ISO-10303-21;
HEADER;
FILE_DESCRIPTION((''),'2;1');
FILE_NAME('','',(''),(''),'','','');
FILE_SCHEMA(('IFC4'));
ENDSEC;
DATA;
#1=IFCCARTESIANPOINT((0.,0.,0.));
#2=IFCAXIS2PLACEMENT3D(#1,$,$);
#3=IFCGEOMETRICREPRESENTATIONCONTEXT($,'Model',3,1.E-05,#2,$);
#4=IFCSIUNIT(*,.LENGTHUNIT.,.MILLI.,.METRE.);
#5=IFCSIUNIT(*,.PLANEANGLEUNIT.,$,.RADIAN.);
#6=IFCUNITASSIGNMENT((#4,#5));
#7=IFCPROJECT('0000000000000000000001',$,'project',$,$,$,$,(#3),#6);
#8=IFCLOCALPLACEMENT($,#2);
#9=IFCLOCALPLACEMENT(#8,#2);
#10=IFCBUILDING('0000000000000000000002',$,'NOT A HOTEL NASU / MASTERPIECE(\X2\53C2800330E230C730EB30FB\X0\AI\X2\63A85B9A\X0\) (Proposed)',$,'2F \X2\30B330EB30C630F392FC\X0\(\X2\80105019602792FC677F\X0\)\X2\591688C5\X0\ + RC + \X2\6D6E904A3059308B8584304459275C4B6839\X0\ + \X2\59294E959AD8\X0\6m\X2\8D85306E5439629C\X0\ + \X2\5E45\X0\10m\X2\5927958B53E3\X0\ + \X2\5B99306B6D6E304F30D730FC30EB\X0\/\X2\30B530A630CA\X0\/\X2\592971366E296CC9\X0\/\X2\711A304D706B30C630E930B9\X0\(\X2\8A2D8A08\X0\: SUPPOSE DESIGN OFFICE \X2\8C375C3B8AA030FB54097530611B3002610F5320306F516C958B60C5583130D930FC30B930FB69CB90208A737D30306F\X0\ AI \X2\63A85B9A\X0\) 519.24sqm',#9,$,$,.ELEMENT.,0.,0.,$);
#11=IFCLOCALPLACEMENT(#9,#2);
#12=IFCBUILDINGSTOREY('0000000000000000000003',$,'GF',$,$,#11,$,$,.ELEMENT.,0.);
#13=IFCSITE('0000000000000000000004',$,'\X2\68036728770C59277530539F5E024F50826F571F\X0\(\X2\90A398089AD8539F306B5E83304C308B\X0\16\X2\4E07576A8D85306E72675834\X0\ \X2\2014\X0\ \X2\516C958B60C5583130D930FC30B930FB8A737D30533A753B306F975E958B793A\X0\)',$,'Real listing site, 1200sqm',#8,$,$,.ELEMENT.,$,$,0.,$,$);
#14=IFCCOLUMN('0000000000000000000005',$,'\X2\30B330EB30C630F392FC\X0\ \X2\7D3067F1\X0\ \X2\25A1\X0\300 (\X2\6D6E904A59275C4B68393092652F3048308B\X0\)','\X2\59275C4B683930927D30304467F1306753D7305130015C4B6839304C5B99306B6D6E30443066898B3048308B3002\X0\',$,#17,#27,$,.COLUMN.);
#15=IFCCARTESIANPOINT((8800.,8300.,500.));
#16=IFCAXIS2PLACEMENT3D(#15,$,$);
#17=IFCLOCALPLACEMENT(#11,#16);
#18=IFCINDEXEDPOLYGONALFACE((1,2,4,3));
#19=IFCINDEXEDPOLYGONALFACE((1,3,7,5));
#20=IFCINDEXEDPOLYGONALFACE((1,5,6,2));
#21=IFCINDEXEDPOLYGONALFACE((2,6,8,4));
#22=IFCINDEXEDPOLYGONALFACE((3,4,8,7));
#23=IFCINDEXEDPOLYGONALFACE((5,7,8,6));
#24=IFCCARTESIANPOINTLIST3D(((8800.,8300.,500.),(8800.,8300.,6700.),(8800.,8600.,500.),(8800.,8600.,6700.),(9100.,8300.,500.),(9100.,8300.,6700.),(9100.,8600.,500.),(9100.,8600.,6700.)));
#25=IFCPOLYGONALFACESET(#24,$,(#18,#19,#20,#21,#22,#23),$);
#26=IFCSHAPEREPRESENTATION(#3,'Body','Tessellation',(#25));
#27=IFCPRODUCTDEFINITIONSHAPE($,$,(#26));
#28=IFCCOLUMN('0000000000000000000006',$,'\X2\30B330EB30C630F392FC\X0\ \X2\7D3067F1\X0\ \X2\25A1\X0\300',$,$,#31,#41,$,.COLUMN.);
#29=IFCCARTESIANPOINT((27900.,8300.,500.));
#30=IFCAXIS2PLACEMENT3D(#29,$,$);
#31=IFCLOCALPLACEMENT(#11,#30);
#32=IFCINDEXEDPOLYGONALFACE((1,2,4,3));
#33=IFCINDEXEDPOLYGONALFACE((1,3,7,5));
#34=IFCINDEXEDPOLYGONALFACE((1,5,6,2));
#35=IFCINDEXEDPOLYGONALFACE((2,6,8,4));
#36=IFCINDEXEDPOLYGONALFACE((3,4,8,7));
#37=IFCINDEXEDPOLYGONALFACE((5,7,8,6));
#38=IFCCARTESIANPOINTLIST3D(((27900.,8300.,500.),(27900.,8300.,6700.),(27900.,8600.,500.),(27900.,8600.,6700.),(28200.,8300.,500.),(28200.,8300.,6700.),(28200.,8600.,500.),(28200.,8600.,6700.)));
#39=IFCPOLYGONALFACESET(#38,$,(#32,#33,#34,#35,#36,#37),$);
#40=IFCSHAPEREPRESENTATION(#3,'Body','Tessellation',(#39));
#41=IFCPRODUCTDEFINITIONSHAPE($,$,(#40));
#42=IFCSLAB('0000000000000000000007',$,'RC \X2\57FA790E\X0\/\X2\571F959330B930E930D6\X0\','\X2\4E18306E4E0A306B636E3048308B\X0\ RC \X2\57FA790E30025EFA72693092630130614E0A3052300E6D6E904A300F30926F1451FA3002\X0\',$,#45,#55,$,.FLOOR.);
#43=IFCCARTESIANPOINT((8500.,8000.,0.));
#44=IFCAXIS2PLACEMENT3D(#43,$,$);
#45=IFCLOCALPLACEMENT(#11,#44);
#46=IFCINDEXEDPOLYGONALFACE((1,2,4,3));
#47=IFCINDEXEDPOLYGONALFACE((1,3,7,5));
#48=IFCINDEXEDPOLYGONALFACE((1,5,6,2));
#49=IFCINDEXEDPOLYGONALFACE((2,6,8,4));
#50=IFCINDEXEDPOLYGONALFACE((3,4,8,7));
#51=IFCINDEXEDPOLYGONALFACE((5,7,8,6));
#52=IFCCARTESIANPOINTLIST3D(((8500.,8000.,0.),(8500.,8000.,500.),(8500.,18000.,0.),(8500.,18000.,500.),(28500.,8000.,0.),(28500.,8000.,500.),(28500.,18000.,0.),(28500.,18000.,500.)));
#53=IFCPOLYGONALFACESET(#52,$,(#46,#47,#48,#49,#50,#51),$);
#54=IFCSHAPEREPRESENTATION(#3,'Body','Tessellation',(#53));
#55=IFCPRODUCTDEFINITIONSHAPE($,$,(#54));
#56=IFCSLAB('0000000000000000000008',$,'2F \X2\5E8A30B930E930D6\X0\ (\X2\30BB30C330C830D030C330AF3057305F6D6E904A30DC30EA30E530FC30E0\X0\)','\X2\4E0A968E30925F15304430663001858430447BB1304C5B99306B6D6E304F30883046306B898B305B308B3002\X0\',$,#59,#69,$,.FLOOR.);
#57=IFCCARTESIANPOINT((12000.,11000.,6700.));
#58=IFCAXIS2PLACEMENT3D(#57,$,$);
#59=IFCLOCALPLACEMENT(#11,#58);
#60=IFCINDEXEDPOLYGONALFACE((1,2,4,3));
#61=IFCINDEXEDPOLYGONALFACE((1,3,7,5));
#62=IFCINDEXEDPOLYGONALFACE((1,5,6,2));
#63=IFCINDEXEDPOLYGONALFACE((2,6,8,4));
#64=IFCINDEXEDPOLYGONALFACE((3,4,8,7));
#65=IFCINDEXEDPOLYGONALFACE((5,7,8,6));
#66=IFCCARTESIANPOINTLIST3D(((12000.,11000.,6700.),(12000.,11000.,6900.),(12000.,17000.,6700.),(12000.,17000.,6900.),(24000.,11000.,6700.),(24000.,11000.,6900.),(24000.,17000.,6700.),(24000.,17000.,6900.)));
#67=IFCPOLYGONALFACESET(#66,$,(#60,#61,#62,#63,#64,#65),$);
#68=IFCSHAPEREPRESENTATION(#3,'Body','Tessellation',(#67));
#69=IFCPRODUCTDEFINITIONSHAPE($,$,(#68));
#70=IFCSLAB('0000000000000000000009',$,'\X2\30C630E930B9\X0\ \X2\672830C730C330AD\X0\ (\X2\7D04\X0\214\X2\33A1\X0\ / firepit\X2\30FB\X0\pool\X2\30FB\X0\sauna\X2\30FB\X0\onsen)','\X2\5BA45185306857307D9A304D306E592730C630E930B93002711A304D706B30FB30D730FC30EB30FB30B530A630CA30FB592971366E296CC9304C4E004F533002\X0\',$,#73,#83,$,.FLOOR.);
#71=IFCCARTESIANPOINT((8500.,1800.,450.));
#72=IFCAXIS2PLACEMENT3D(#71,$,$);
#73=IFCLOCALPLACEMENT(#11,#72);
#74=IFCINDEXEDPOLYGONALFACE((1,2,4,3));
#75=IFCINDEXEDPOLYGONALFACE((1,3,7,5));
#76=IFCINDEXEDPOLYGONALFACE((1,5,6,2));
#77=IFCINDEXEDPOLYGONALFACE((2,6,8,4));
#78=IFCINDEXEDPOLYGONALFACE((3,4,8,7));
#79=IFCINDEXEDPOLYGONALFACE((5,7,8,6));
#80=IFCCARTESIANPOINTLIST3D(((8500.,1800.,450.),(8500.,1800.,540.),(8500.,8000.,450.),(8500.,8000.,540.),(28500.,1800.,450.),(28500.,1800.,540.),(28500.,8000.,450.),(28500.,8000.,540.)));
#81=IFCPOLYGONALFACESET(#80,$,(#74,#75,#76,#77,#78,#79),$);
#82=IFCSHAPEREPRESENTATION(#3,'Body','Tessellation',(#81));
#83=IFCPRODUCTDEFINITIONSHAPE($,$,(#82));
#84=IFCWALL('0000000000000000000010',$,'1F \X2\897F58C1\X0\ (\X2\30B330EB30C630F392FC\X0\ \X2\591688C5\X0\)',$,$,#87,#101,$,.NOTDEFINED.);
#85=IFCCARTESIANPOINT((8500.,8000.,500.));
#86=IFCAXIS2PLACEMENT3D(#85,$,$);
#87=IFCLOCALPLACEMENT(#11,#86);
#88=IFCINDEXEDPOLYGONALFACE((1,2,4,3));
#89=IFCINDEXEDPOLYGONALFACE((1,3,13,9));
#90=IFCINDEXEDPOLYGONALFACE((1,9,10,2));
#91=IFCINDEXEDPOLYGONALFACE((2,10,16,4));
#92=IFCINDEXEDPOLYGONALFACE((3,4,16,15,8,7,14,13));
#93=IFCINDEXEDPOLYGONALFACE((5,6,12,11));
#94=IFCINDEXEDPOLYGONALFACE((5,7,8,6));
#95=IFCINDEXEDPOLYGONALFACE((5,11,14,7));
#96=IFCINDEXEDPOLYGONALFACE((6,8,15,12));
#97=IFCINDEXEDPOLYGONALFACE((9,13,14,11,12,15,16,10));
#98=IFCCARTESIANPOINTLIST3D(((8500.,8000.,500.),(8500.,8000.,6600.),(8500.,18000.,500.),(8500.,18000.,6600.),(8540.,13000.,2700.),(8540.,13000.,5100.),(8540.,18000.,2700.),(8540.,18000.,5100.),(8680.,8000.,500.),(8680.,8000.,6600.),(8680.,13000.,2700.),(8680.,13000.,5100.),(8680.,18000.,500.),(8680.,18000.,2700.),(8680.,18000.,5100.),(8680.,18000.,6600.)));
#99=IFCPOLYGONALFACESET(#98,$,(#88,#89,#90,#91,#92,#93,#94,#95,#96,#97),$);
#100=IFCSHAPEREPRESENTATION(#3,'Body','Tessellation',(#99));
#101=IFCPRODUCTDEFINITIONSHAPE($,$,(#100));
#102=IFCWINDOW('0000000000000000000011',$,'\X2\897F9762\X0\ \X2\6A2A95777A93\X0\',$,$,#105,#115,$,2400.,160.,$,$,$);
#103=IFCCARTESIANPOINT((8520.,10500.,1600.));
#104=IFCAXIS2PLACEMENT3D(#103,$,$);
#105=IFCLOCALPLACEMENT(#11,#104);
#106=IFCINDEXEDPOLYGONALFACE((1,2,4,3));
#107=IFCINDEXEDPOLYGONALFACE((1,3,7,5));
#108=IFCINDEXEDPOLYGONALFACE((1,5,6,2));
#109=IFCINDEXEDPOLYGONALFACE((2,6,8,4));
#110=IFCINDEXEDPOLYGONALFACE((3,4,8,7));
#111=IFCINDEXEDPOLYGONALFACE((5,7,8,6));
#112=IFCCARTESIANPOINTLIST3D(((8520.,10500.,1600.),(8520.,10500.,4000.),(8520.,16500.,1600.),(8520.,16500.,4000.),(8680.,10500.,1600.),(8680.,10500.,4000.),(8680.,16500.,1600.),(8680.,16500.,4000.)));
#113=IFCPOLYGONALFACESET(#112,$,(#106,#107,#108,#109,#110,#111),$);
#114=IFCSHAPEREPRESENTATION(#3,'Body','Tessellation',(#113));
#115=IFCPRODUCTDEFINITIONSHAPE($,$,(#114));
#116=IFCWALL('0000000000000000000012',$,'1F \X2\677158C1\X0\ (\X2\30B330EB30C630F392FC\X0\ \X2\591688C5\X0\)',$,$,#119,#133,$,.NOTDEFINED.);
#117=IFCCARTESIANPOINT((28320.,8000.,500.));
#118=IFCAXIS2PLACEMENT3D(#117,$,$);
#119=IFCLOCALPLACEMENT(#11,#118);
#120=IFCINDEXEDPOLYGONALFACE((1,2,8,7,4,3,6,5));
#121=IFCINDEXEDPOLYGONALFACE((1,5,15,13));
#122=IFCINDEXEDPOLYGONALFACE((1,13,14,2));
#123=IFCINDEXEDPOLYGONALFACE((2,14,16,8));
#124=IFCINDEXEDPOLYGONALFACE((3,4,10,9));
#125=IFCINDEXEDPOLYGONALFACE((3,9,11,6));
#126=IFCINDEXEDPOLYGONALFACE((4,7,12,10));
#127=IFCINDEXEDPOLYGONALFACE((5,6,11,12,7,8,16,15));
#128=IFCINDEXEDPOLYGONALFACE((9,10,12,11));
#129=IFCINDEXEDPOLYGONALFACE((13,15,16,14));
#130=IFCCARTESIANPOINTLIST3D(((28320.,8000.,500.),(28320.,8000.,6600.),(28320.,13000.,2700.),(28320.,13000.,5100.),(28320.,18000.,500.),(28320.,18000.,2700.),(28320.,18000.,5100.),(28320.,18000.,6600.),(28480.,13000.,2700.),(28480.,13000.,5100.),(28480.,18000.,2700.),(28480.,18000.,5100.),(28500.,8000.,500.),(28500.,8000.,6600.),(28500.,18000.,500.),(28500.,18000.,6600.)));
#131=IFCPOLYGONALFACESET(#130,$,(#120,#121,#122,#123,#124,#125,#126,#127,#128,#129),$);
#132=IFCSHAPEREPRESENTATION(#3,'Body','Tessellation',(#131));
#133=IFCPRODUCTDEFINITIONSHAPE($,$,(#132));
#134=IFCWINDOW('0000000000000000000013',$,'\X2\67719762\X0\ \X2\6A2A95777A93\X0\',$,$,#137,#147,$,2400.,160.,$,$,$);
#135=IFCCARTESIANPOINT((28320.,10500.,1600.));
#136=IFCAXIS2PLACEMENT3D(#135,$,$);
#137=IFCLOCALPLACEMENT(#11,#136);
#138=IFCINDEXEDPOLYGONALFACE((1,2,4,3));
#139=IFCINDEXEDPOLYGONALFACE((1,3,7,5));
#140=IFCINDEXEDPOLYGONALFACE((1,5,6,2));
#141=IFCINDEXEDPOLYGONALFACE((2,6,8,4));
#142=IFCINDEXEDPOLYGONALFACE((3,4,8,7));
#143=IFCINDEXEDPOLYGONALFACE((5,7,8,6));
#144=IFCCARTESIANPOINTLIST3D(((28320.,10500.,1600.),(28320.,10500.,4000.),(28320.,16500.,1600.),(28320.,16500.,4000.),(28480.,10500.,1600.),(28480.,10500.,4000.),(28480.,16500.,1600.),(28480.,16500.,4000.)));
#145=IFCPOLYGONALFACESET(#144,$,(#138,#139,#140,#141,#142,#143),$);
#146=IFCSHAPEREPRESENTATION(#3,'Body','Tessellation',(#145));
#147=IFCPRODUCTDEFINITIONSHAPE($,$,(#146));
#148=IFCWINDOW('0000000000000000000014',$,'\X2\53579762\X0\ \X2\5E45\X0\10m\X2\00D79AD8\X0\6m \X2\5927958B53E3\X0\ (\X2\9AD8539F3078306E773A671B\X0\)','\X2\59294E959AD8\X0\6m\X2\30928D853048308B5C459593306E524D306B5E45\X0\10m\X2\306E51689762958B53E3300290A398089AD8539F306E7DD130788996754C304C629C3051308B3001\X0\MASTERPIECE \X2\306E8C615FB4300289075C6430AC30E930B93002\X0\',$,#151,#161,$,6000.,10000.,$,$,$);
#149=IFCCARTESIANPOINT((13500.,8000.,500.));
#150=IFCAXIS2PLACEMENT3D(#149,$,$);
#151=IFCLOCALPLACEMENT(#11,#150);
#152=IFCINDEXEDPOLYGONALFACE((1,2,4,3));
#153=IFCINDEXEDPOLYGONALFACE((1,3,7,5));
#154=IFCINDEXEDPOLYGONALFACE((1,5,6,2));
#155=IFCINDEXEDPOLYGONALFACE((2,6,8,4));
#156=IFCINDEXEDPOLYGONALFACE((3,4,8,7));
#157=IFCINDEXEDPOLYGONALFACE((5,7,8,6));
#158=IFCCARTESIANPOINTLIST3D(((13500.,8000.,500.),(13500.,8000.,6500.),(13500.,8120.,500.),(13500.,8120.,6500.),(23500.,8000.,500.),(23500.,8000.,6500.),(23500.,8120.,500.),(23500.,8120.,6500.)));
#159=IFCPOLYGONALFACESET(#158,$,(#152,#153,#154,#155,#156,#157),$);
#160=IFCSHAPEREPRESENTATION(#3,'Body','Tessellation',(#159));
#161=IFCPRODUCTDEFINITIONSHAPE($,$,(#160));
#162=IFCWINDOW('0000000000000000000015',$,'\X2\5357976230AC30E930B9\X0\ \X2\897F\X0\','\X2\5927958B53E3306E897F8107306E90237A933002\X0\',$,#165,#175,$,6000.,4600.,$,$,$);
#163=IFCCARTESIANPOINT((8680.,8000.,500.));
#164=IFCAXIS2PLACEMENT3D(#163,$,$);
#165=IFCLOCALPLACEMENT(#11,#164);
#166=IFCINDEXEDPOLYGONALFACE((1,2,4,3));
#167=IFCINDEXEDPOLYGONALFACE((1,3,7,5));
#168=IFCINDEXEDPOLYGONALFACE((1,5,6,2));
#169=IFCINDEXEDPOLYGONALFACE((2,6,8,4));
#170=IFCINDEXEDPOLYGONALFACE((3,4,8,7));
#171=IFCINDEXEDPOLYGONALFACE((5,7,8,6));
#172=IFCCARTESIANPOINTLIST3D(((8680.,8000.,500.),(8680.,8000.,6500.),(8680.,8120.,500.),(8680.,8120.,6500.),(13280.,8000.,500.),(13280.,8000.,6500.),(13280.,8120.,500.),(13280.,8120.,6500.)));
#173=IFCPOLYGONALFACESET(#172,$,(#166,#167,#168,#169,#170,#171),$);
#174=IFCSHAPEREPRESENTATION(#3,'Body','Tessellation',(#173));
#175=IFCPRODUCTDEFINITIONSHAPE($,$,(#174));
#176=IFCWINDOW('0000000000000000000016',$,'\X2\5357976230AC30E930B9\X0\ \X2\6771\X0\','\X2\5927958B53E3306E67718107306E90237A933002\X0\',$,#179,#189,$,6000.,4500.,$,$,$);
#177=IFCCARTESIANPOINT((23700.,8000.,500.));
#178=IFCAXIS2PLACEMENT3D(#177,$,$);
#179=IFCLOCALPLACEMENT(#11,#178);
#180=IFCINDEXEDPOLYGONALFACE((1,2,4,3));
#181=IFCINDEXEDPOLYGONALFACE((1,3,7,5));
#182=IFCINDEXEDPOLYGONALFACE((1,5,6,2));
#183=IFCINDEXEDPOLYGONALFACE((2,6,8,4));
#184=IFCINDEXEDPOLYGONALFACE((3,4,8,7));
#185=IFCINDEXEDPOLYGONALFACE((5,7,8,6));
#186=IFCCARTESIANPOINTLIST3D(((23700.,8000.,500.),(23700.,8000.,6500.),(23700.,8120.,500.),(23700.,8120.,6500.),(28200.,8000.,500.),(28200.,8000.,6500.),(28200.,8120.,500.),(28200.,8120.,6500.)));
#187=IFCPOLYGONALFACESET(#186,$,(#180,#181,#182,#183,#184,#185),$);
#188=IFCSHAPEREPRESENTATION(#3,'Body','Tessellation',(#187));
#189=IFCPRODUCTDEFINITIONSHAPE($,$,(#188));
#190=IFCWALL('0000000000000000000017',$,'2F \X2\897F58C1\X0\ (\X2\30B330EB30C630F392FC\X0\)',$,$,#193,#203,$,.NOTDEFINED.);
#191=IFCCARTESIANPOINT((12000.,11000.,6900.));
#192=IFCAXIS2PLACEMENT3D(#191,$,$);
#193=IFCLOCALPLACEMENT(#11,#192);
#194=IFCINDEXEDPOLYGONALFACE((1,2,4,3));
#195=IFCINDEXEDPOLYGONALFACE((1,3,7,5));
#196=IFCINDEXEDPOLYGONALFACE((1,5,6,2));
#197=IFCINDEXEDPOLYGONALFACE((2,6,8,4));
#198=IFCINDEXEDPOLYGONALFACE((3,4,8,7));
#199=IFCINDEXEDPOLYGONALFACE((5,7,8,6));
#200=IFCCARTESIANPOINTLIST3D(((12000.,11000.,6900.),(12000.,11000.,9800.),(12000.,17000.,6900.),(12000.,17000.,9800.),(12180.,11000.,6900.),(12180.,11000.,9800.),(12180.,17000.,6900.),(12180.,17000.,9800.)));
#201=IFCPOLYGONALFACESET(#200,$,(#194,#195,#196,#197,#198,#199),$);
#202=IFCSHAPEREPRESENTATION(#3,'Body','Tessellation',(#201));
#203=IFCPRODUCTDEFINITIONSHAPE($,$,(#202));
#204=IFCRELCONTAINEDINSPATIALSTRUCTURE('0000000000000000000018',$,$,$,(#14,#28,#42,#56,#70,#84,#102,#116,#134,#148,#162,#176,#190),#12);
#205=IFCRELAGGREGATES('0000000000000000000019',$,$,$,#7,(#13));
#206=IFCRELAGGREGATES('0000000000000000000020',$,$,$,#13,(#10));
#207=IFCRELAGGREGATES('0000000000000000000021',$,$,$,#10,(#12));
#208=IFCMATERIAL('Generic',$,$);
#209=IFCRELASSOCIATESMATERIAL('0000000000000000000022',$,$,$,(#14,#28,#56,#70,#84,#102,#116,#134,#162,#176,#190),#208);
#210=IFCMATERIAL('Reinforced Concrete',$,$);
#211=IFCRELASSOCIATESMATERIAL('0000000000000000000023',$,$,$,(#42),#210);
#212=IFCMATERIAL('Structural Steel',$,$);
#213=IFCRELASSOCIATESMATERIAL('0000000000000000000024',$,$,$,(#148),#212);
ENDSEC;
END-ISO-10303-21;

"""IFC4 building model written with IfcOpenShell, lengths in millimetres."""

from ifc_helpers import new_model, si_unit, frame, frame_2d, origin, place, context, project, spatial, rectangle, extrude, material, element, fill, save


model = new_model("IFC4")

# Units and contexts
model_context = context("Model", 3, precision=1e-05, world=origin())
ifc_project = project(units=[si_unit("LENGTHUNIT", "METRE", prefix="MILLI"), si_unit("PLANEANGLEUNIT", "RADIAN")], contexts=[model_context])

# Site, building, storey
site_placement = place(None, origin())
site = spatial("IfcSite", under=ifc_project, at=site_placement, Name="栃木県大田原市佐良土(那須高原に広がる16万坪超の牧場 — 公開情報ベース・詳細区画は非開示)", ObjectType="Real listing site, 1200sqm", CompositionType="ELEMENT", RefElevation=0.0)
building_placement = place(site_placement, origin())
building = spatial("IfcBuilding", under=site, at=building_placement, Name="NOT A HOTEL NASU / MASTERPIECE(参考モデル・AI推定) (Proposed)", ObjectType="2F コルテン鋼(耐候性鋼板)外装 + RC + 浮遊する薄い大屋根 + 天井高6m超の吹抜 + 幅10m大開口 + 宙に浮くプール/サウナ/天然温泉/焚き火テラス(設計: SUPPOSE DESIGN OFFICE 谷尻誠・吉田愛。意匠は公開情報ベース・構造詳細は AI 推定) 519.24sqm", CompositionType="ELEMENT", ElevationOfRefHeight=0.0, ElevationOfTerrain=0.0)
storey_placement = place(building_placement, origin())
storey = spatial("IfcBuildingStorey", under=building, at=storey_placement, Name="GF", CompositionType="ELEMENT", Elevation=0.0)

# Columns
ifc_material_1 = material(Name="Generic")
column_1_placement = place(storey_placement, frame((8800.0, 8300.0, 500.0)))
element("IfcColumn", 1, at=column_1_placement, inside=storey, material=ifc_material_1, Name="コルテン鋼 細柱 □300 (浮遊大屋根を支える)", Description="大屋根を細い柱で受け、屋根が宙に浮いて見える。", PredefinedType="COLUMN", context=model_context, shape_type="SweptSolid", body=[
    extrude(rectangle(XDim=300.0, YDim=300.0, at=frame_2d((150.0, 150.0))), frame((8800.0, 8300.0, 500.0)), (0.0, 0.0, 1.0), 6200.0),
])
column_2_placement = place(storey_placement, frame((27900.0, 8300.0, 500.0)))
element("IfcColumn", 2, at=column_2_placement, inside=storey, material=ifc_material_1, Name="コルテン鋼 細柱 □300", PredefinedType="COLUMN", context=model_context, shape_type="SweptSolid", body=[
    extrude(rectangle(XDim=300.0, YDim=300.0, at=frame_2d((150.0, 150.0))), frame((27900.0, 8300.0, 500.0)), (0.0, 0.0, 1.0), 6200.0),
])

# Slabs
ifc_material_2 = material(Name="Reinforced Concrete")
slab_1_placement = place(storey_placement, frame((8500.0, 8000.0, 0.0)))
element("IfcSlab", 3, at=slab_1_placement, inside=storey, material=ifc_material_2, Name="RC 基礎/土間スラブ", Description="丘の上に据える RC 基礎。建物を持ち上げ『浮遊』を演出。", PredefinedType="FLOOR", context=model_context, shape_type="SweptSolid", body=[
    extrude(rectangle(XDim=20000.0, YDim=10000.0, at=frame_2d((10000.0, 5000.0))), frame((8500.0, 8000.0, 0.0)), (0.0, 0.0, 1.0), 500.0),
])
slab_2_placement = place(storey_placement, frame((12000.0, 11000.0, 6700.0)))
element("IfcSlab", 4, at=slab_2_placement, inside=storey, material=ifc_material_1, Name="2F 床スラブ (セットバックした浮遊ボリューム)", Description="上階を引いて、薄い箱が宙に浮くように見せる。", PredefinedType="FLOOR", context=model_context, shape_type="SweptSolid", body=[
    extrude(rectangle(XDim=12000.0, YDim=6000.0, at=frame_2d((6000.0, 3000.0))), frame((12000.0, 11000.0, 6700.0)), (0.0, 0.0, 1.0), 200.0),
])
slab_3_placement = place(storey_placement, frame((8500.0, 1800.0, 450.0)))
element("IfcSlab", 5, at=slab_3_placement, inside=storey, material=ifc_material_1, Name="テラス 木デッキ (約214㎡ / firepit・pool・sauna・onsen)", Description="室内と地続きの大テラス。焚き火・プール・サウナ・天然温泉が一体。", PredefinedType="FLOOR", context=model_context, shape_type="SweptSolid", body=[
    extrude(rectangle(XDim=20000.0, YDim=6200.0, at=frame_2d((10000.0, 3100.0))), frame((8500.0, 1800.0, 450.0)), (0.0, 0.0, 1.0), 90.0),
])

# Walls, openings, windows
wall_1_placement = place(storey_placement, frame((8500.0, 8000.0, 500.0)))
wall_1 = element("IfcWall", 6, at=wall_1_placement, inside=storey, material=ifc_material_1, Name="1F 西壁 (コルテン鋼 外装)", PredefinedType="NOTDEFINED", context=model_context, shape_type="SweptSolid", body=[
    extrude(rectangle(XDim=180.0, YDim=10000.0, at=frame_2d((90.0, 5000.0))), frame((8500.0, 8000.0, 500.0)), (0.0, 0.0, 1.0), 6100.0),
])
opening_1_placement = place(storey_placement, frame((8520.0, 10500.0, 1600.0)))
opening_1 = element("IfcOpeningElement", 7, at=opening_1_placement, cuts=wall_1, PredefinedType="NOTDEFINED", context=model_context, shape_type="SweptSolid", body=[
    extrude(rectangle(XDim=160.0, YDim=6000.0, at=frame_2d((80.0, 3000.0))), frame((8520.0, 10500.0, 1600.0)), (0.0, 0.0, 1.0), 2400.0),
])
window_1_placement = place(storey_placement, frame((8520.0, 10500.0, 1600.0)))
window_1 = element("IfcWindow", 8, at=window_1_placement, inside=storey, material=ifc_material_1, Name="西面 横長窓", OverallHeight=2400.0, OverallWidth=160.0, context=model_context, shape_type="SweptSolid", body=[
    extrude(rectangle(XDim=160.0, YDim=6000.0, at=frame_2d((80.0, 3000.0))), frame((8520.0, 10500.0, 1600.0)), (0.0, 0.0, 1.0), 2400.0),
])
fill(opening_1, window_1)
wall_2_placement = place(storey_placement, frame((28320.0, 8000.0, 500.0)))
wall_2 = element("IfcWall", 9, at=wall_2_placement, inside=storey, material=ifc_material_1, Name="1F 東壁 (コルテン鋼 外装)", PredefinedType="NOTDEFINED", context=model_context, shape_type="SweptSolid", body=[
    extrude(rectangle(XDim=180.0, YDim=10000.0, at=frame_2d((90.0, 5000.0))), frame((28320.0, 8000.0, 500.0)), (0.0, 0.0, 1.0), 6100.0),
])
opening_2_placement = place(storey_placement, frame((28320.0, 10500.0, 1600.0)))
opening_2 = element("IfcOpeningElement", 10, at=opening_2_placement, cuts=wall_2, PredefinedType="NOTDEFINED", context=model_context, shape_type="SweptSolid", body=[
    extrude(rectangle(XDim=160.0, YDim=6000.0, at=frame_2d((80.0, 3000.0))), frame((28320.0, 10500.0, 1600.0)), (0.0, 0.0, 1.0), 2400.0),
])
window_2_placement = place(storey_placement, frame((28320.0, 10500.0, 1600.0)))
window_2 = element("IfcWindow", 11, at=window_2_placement, inside=storey, material=ifc_material_1, Name="東面 横長窓", OverallHeight=2400.0, OverallWidth=160.0, context=model_context, shape_type="SweptSolid", body=[
    extrude(rectangle(XDim=160.0, YDim=6000.0, at=frame_2d((80.0, 3000.0))), frame((28320.0, 10500.0, 1600.0)), (0.0, 0.0, 1.0), 2400.0),
])
fill(opening_2, window_2)

# Windows
ifc_material_3 = material(Name="Structural Steel")
window_3_placement = place(storey_placement, frame((13500.0, 8000.0, 500.0)))
element("IfcWindow", 12, at=window_3_placement, inside=storey, material=ifc_material_3, Name="南面 幅10m×高6m 大開口 (高原への眺望)", Description="天井高6mを超える居間の前に幅10mの全面開口。那須高原の緑へ視界が抜ける、MASTERPIECE の象徴。複層ガラス。", OverallHeight=6000.0, OverallWidth=10000.0, context=model_context, shape_type="SweptSolid", body=[
    extrude(rectangle(XDim=10000.0, YDim=120.0, at=frame_2d((5000.0, 60.0))), frame((13500.0, 8000.0, 500.0)), (0.0, 0.0, 1.0), 6000.0),
])
window_4_placement = place(storey_placement, frame((8680.0, 8000.0, 500.0)))
element("IfcWindow", 13, at=window_4_placement, inside=storey, material=ifc_material_1, Name="南面ガラス 西", Description="大開口の西脇の連窓。", OverallHeight=6000.0, OverallWidth=4600.0, context=model_context, shape_type="SweptSolid", body=[
    extrude(rectangle(XDim=4600.0, YDim=120.0, at=frame_2d((2300.0, 60.0))), frame((8680.0, 8000.0, 500.0)), (0.0, 0.0, 1.0), 6000.0),
])
window_5_placement = place(storey_placement, frame((23700.0, 8000.0, 500.0)))
element("IfcWindow", 14, at=window_5_placement, inside=storey, material=ifc_material_1, Name="南面ガラス 東", Description="大開口の東脇の連窓。", OverallHeight=6000.0, OverallWidth=4500.0, context=model_context, shape_type="SweptSolid", body=[
    extrude(rectangle(XDim=4500.0, YDim=120.0, at=frame_2d((2250.0, 60.0))), frame((23700.0, 8000.0, 500.0)), (0.0, 0.0, 1.0), 6000.0),
])

# Wall
wall_3_placement = place(storey_placement, frame((12000.0, 11000.0, 6900.0)))
element("IfcWall", 15, at=wall_3_placement, inside=storey, material=ifc_material_1, Name="2F 西壁 (コルテン鋼)", PredefinedType="NOTDEFINED", context=model_context, shape_type="SweptSolid", body=[
    extrude(rectangle(XDim=180.0, YDim=6000.0, at=frame_2d((90.0, 3000.0))), frame((12000.0, 11000.0, 6900.0)), (0.0, 0.0, 1.0), 2900.0),
])

save(model, "model.ifc")
